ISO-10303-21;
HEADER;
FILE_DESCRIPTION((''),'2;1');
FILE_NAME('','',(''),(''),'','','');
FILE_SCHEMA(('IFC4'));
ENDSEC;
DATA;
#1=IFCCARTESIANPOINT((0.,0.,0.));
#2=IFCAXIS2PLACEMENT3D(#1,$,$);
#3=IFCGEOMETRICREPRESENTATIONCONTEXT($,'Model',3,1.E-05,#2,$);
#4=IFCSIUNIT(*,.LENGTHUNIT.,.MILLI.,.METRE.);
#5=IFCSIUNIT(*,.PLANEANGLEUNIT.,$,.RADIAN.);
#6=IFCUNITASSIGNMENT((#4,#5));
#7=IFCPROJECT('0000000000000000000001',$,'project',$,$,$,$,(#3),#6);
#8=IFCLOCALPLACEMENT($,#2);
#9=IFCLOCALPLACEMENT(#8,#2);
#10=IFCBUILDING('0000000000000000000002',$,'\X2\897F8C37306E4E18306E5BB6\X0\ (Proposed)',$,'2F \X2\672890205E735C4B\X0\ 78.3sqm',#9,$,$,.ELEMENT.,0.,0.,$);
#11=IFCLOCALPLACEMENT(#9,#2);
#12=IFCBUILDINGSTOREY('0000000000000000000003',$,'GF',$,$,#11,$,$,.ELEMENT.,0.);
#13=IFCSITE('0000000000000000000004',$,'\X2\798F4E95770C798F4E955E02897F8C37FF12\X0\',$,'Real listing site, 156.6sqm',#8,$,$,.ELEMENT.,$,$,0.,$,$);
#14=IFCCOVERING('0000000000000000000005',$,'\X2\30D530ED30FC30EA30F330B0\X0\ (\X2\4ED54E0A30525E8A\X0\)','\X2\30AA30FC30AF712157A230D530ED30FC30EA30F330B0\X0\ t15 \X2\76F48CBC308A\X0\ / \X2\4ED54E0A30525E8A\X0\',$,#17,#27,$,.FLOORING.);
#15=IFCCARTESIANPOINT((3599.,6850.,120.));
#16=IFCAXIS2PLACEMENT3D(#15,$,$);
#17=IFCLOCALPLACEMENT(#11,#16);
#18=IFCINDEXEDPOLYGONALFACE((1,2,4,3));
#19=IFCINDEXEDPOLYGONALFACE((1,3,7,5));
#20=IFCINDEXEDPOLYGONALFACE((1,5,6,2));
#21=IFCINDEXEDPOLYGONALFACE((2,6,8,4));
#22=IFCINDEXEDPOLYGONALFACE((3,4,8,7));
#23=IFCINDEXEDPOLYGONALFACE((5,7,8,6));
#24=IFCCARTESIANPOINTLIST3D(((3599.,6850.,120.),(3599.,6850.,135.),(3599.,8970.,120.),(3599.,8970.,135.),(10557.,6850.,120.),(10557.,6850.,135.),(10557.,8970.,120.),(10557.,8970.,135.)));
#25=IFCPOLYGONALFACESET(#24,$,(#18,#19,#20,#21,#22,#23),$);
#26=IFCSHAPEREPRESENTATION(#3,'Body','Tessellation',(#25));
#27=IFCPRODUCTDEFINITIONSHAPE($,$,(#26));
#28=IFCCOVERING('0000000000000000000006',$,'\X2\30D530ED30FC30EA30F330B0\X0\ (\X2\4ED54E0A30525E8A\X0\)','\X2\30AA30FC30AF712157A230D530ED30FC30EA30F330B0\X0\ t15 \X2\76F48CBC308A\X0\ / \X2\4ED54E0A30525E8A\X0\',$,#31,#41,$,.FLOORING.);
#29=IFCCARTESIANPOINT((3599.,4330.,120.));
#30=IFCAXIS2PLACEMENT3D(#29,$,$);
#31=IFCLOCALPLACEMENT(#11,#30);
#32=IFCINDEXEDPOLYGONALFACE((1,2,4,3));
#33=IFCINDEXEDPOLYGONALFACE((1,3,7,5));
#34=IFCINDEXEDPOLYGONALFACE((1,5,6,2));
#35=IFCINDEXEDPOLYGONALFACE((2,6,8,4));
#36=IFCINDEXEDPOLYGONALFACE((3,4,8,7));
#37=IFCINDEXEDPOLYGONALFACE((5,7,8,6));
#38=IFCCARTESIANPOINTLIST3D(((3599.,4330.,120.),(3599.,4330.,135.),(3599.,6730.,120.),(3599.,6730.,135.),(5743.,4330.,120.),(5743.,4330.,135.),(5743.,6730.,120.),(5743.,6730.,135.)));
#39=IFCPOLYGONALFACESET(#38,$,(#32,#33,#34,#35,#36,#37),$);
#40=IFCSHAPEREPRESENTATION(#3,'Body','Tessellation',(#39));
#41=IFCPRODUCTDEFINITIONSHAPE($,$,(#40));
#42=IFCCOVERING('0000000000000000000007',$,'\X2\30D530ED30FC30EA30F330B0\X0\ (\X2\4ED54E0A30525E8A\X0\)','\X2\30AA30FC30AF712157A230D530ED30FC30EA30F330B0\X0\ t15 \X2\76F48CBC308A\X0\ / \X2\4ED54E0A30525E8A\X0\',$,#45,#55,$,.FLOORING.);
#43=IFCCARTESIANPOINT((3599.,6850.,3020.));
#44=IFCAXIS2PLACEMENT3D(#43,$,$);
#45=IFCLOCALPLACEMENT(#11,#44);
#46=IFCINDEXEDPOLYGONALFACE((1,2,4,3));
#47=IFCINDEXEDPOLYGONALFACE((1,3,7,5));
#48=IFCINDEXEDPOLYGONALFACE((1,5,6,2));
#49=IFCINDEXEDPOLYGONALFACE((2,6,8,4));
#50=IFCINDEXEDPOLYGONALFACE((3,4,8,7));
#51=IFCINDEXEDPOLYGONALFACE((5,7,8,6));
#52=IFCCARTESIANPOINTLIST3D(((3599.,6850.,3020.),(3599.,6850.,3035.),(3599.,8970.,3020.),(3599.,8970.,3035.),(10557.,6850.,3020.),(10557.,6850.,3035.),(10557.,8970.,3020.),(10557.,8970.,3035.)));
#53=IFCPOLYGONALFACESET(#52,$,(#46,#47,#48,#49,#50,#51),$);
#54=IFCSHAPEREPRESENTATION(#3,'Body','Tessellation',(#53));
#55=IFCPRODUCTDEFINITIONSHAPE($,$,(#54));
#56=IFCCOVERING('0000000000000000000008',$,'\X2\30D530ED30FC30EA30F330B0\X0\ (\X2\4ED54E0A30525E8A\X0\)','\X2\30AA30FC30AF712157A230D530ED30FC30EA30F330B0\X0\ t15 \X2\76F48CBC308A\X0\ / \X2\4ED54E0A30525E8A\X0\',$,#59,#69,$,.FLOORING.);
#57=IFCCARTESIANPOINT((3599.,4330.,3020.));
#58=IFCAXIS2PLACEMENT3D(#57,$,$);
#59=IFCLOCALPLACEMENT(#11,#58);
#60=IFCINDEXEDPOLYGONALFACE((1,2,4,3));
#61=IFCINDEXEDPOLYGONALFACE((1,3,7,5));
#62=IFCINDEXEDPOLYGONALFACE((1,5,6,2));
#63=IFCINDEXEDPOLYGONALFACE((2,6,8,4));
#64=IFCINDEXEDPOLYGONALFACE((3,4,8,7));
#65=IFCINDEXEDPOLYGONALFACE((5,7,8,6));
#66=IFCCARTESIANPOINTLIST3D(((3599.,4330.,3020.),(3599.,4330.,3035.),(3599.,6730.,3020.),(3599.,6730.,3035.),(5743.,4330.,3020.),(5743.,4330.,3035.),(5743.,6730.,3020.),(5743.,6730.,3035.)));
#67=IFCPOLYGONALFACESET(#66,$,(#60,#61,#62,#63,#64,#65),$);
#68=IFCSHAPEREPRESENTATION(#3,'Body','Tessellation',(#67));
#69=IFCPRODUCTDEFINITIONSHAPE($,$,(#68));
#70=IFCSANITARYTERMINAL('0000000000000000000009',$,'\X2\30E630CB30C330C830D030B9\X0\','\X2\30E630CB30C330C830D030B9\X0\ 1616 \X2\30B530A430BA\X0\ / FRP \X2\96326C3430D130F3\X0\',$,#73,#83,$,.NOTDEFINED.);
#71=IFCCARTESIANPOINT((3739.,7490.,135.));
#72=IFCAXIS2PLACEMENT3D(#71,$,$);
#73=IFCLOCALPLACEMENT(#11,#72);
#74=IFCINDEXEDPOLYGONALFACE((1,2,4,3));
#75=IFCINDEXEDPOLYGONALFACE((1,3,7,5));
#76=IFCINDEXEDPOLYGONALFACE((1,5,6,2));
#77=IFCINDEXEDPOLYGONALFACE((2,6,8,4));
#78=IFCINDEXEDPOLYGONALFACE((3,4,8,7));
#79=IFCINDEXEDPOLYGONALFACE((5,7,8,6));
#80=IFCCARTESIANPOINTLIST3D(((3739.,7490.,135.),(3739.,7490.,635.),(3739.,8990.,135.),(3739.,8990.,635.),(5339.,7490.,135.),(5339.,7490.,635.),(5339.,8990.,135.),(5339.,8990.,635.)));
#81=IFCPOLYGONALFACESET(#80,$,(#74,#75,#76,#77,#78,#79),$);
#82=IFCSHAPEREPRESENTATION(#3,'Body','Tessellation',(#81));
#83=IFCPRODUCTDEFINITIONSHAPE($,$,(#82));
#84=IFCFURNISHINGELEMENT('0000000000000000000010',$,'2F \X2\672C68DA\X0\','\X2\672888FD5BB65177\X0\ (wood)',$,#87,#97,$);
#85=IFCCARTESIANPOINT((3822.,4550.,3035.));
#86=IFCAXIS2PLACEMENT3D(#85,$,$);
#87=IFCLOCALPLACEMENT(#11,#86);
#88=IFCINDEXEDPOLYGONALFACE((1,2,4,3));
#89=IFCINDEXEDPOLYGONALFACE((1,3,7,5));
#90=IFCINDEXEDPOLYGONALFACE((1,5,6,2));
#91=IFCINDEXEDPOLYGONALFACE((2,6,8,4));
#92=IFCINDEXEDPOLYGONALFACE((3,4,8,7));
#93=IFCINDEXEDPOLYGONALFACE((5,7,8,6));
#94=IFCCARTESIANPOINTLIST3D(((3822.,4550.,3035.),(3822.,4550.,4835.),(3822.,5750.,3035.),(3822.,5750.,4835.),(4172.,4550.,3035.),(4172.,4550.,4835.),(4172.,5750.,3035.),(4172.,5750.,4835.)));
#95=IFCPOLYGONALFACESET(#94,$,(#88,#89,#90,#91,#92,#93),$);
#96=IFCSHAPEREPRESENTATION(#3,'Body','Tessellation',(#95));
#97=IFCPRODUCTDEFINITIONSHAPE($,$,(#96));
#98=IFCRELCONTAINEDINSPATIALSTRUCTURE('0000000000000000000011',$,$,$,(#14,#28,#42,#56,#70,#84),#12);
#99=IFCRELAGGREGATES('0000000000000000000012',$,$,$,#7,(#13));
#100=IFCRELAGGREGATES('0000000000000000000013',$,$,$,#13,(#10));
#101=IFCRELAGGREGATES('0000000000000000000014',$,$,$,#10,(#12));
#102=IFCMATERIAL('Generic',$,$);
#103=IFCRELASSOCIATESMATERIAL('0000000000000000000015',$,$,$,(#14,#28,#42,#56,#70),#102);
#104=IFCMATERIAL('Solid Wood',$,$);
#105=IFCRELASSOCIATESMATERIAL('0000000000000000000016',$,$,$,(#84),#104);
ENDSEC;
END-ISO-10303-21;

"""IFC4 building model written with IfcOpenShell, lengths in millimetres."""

from ifc_helpers import new_model, si_unit, frame, frame_2d, origin, place, context, project, spatial, rectangle, extrude, material, element, save


model = new_model("IFC4")

# Units and contexts
model_context = context("Model", 3, precision=1e-05, world=origin())
ifc_project = project(units=[si_unit("LENGTHUNIT", "METRE", prefix="MILLI"), si_unit("PLANEANGLEUNIT", "RADIAN")], contexts=[model_context])

# Site, building, storey
site_placement = place(None, origin())
site = spatial("IfcSite", under=ifc_project, at=site_placement, Name="福井県福井市西谷２", ObjectType="Real listing site, 156.6sqm", CompositionType="ELEMENT", RefElevation=0.0)
building_placement = place(site_placement, origin())
building = spatial("IfcBuilding", under=site, at=building_placement, Name="西谷の丘の家 (Proposed)", ObjectType="2F 木造平屋 78.3sqm", CompositionType="ELEMENT", ElevationOfRefHeight=0.0, ElevationOfTerrain=0.0)
storey_placement = place(building_placement, origin())
storey = spatial("IfcBuildingStorey", under=building, at=storey_placement, Name="GF", CompositionType="ELEMENT", Elevation=0.0)

# Shared definitions
ifc_material_1 = material(Name="Solid Wood")

# Coverings
ifc_material_2 = material(Name="Generic")
covering_1_placement = place(storey_placement, frame((3599.0, 6850.0, 120.0)))
element("IfcCovering", 1, at=covering_1_placement, inside=storey, material=ifc_material_2, Name="フローリング (仕上げ床)", Description="オーク無垢フローリング t15 直貼り / 仕上げ床", PredefinedType="FLOORING", context=model_context, shape_type="SweptSolid", body=[
    extrude(rectangle(XDim=6958.0, YDim=2120.0, at=frame_2d((3479.0, 1060.0))), frame((3599.0, 6850.0, 120.0)), (0.0, 0.0, 1.0), 15.0),
])
covering_2_placement = place(storey_placement, frame((3599.0, 4330.0, 120.0)))
element("IfcCovering", 2, at=covering_2_placement, inside=storey, material=ifc_material_2, Name="フローリング (仕上げ床)", Description="オーク無垢フローリング t15 直貼り / 仕上げ床", PredefinedType="FLOORING", context=model_context, shape_type="SweptSolid", body=[
    extrude(rectangle(XDim=2144.0, YDim=2400.0, at=frame_2d((1072.0, 1200.0))), frame((3599.0, 4330.0, 120.0)), (0.0, 0.0, 1.0), 15.0),
])
covering_3_placement = place(storey_placement, frame((3599.0, 6850.0, 3020.0)))
element("IfcCovering", 3, at=covering_3_placement, inside=storey, material=ifc_material_2, Name="フローリング (仕上げ床)", Description="オーク無垢フローリング t15 直貼り / 仕上げ床", PredefinedType="FLOORING", context=model_context, shape_type="SweptSolid", body=[
    extrude(rectangle(XDim=6958.0, YDim=2120.0, at=frame_2d((3479.0, 1060.0))), frame((3599.0, 6850.0, 3020.0)), (0.0, 0.0, 1.0), 15.0),
])
covering_4_placement = place(storey_placement, frame((3599.0, 4330.0, 3020.0)))
element("IfcCovering", 4, at=covering_4_placement, inside=storey, material=ifc_material_2, Name="フローリング (仕上げ床)", Description="オーク無垢フローリング t15 直貼り / 仕上げ床", PredefinedType="FLOORING", context=model_context, shape_type="SweptSolid", body=[
    extrude(rectangle(XDim=2144.0, YDim=2400.0, at=frame_2d((1072.0, 1200.0))), frame((3599.0, 4330.0, 3020.0)), (0.0, 0.0, 1.0), 15.0),
])

# Sanitary terminal
sanitary_terminal_placement = place(storey_placement, frame((3739.0, 7490.0, 135.0)))
element("IfcSanitaryTerminal", 5, at=sanitary_terminal_placement, inside=storey, material=ifc_material_2, Name="ユニットバス", Description="ユニットバス 1616 サイズ / FRP 防水パン", PredefinedType="NOTDEFINED", context=model_context, shape_type="SweptSolid", body=[
    extrude(rectangle(XDim=1600.0, YDim=1500.0, at=frame_2d((800.0, 750.0))), frame((3739.0, 7490.0, 135.0)), (0.0, 0.0, 1.0), 500.0),
])

# Furnishing element
furnishing_placement = place(storey_placement, frame((3822.0, 4550.0, 3035.0)))
element("IfcFurnishingElement", 6, at=furnishing_placement, inside=storey, material=ifc_material_1, Name="2F 本棚", Description="木製家具 (wood)", context=model_context, shape_type="SweptSolid", body=[
    extrude(rectangle(XDim=350.0, YDim=1200.0, at=frame_2d((175.0, 600.0))), frame((3822.0, 4550.0, 3035.0)), (0.0, 0.0, 1.0), 1800.0),
])

save(model, "model.ifc")
